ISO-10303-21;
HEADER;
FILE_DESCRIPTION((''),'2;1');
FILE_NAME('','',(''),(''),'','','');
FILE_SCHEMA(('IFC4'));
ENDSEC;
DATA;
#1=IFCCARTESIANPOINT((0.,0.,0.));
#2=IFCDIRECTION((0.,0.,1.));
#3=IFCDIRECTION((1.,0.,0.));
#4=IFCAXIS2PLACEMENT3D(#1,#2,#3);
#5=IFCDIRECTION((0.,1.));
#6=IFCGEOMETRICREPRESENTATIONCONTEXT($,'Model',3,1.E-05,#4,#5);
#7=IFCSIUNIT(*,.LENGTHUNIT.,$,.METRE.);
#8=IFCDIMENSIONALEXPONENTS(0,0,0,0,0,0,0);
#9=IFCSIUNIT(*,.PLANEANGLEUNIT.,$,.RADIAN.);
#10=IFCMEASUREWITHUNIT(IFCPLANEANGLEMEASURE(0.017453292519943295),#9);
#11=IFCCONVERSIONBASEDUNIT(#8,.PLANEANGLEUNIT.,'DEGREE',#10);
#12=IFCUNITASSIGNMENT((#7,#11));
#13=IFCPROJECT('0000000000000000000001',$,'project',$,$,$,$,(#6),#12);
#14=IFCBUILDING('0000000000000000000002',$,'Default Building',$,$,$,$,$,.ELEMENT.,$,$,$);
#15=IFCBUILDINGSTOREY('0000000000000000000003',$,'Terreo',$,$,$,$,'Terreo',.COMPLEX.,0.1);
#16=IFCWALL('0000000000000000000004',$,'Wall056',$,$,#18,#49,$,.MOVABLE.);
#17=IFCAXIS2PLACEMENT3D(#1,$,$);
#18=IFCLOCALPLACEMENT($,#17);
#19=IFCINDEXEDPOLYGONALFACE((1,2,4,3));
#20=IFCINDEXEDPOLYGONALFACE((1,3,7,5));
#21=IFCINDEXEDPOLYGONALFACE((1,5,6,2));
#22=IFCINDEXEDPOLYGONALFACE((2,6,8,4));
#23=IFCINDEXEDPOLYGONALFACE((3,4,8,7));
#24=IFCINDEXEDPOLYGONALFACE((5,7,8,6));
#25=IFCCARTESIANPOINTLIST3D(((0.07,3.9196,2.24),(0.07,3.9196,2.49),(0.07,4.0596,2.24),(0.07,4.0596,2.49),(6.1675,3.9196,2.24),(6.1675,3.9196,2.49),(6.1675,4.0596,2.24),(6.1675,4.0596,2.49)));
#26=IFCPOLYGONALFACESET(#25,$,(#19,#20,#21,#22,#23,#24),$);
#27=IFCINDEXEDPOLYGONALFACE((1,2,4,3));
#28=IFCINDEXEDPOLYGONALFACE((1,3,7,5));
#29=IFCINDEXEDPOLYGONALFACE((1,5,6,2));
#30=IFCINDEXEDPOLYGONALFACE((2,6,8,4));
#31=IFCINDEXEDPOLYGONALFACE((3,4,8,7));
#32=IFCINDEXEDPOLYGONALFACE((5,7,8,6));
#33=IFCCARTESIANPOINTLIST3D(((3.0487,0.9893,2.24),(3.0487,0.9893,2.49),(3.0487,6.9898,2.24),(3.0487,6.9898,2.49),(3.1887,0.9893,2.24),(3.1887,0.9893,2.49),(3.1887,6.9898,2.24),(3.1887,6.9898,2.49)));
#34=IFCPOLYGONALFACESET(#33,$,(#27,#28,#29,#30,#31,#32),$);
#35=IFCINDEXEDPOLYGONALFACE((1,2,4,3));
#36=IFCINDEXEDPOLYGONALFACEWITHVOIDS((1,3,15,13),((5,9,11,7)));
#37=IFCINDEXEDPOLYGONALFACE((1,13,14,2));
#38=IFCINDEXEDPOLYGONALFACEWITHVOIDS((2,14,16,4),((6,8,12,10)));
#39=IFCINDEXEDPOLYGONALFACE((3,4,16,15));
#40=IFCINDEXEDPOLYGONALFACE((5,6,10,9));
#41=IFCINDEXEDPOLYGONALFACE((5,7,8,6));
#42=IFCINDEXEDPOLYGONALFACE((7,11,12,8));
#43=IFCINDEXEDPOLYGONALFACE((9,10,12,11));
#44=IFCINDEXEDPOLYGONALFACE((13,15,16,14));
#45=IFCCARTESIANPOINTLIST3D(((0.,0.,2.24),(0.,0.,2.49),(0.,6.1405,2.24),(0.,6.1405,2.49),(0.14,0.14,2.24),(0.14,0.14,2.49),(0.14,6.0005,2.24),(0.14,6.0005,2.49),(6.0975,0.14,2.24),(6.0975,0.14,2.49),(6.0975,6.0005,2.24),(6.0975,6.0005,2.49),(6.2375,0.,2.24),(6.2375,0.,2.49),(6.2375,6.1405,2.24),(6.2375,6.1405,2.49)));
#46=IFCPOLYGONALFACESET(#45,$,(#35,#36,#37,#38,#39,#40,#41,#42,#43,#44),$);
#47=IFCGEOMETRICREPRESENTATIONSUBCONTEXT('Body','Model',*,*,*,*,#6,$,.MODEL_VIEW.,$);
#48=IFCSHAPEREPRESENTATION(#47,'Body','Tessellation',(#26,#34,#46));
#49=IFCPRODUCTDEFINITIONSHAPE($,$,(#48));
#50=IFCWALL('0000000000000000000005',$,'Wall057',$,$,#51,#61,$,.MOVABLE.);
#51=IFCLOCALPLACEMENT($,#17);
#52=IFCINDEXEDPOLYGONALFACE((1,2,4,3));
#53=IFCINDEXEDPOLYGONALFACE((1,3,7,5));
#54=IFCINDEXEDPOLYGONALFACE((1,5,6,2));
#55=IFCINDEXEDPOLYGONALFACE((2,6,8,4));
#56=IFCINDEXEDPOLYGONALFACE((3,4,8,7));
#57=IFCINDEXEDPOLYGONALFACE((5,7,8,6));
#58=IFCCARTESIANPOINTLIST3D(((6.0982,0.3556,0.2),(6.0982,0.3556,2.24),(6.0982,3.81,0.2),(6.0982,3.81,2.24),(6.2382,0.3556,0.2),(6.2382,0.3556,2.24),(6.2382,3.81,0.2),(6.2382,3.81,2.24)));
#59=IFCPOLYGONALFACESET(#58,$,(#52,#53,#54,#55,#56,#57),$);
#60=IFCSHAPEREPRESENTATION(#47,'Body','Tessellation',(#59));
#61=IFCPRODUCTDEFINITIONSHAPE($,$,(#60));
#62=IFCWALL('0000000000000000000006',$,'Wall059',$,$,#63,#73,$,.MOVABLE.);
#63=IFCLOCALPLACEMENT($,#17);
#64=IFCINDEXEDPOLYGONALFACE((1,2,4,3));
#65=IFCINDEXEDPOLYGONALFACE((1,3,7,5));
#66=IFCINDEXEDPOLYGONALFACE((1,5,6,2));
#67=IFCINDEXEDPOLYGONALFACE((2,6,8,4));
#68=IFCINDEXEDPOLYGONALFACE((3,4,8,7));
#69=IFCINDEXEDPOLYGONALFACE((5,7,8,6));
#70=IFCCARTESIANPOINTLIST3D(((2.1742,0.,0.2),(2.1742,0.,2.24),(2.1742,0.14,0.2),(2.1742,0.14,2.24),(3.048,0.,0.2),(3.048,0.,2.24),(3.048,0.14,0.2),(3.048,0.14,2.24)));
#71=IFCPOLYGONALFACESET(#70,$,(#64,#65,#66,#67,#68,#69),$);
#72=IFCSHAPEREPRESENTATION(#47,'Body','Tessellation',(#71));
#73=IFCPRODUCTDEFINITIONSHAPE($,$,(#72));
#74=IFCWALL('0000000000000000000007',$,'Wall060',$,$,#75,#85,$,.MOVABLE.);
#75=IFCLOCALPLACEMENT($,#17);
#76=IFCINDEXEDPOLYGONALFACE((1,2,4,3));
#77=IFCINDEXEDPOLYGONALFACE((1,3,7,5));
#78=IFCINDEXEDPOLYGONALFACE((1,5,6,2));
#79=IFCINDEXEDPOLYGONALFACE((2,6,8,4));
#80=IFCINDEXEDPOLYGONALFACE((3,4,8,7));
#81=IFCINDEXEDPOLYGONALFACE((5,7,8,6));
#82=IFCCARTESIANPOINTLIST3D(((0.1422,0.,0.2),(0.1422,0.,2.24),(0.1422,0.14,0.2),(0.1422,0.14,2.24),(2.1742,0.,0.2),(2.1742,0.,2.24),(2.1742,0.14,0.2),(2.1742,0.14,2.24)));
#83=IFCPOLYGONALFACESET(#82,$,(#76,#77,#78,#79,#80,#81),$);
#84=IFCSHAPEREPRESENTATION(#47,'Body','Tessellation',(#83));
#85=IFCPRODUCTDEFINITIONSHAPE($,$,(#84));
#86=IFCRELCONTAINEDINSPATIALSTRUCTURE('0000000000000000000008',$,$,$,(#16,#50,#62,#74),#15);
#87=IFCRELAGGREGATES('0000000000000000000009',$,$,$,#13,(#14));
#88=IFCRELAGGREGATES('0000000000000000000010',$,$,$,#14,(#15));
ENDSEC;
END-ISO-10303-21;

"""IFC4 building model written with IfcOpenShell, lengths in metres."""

from ifc_helpers import new_model, entity, si_unit, converted_unit, direction, frame, frame_2d, origin_with_axes, origin_2d_with_axis, place, context, subcontext, project, spatial, polyline, rectangle, outline, extrude, element, save


model = new_model("IFC4")

# Units and contexts
model_context = context("Model", 3, precision=1e-05, world=origin_with_axes(), true_north=direction((0.0, 1.0)))
body_context = subcontext(model_context, "Body", "Model", "MODEL_VIEW")
ifc_project = project(units=[si_unit("LENGTHUNIT", "METRE"), converted_unit("PLANEANGLEUNIT", "DEGREE", entity("IfcPlaneAngleMeasure", 0.017453292519943295), si_unit("PLANEANGLEUNIT", "RADIAN"), dimensions=[0, 0, 0, 0, 0, 0, 0])], contexts=[model_context])

# Building, storey
building = spatial("IfcBuilding", under=ifc_project, Name="Default Building", CompositionType="ELEMENT")
storey = spatial("IfcBuildingStorey", under=building, Name="Terreo", LongName="Terreo", CompositionType="COMPLEX", Elevation=0.1)

# Shared definitions
placement = place(None, origin_with_axes())

# Walls
element("IfcWall", 1, at=placement, inside=storey, Name="Wall056", PredefinedType="MOVABLE", context=body_context, shape_type="SweptSolid", body=[
    extrude(rectangle(XDim=6.0975, YDim=0.14, at=origin_2d_with_axis()), frame((3.1187, 3.9896, 2.24), z_axis=(0.0, 0.0, 1.0), x_axis=(1.0, 0.0, 0.0)), (0.0, 0.0, 1.0), 0.25),
    extrude(rectangle(XDim=6.0005, YDim=0.14, at=frame_2d((0.0, 0.0), x_axis=(0.0, 1.0))), frame((3.1187, 3.9896, 2.24), z_axis=(0.0, 0.0, 1.0), x_axis=(1.0, 0.0, 0.0)), (0.0, 0.0, 1.0), 0.25),
    extrude(outline(polyline([(-3.1187, -3.9896), (3.1187, -3.9896), (3.1187, 2.151), (-3.1187, 2.151), (-3.1187, -3.9896)]), holes=[polyline([(2.9787, -3.8496), (2.9787, 2.011), (-2.9787, 2.011), (-2.9787, -3.8496), (2.9787, -3.8496)])]), frame((3.1187, 3.9896, 2.24), z_axis=(0.0, 0.0, 1.0), x_axis=(1.0, 0.0, 0.0)), (0.0, 0.0, 1.0), 0.25),
])
element("IfcWall", 2, at=placement, inside=storey, Name="Wall057", PredefinedType="MOVABLE", context=body_context, shape_type="SweptSolid", body=[
    extrude(rectangle(XDim=3.4544, YDim=0.14, at=frame_2d((0.0, 0.0), x_axis=(0.0, 1.0))), frame((6.1682, 2.0828, 0.2), z_axis=(0.0, 0.0, 1.0), x_axis=(1.0, 0.0, 0.0)), (0.0, 0.0, 1.0), 2.04),
])
element("IfcWall", 3, at=placement, inside=storey, Name="Wall059", PredefinedType="MOVABLE", context=body_context, shape_type="SweptSolid", body=[
    extrude(rectangle(XDim=0.8738, YDim=0.14, at=origin_2d_with_axis()), frame((2.6111, 0.07, 0.2), z_axis=(0.0, 0.0, 1.0), x_axis=(1.0, 0.0, 0.0)), (0.0, 0.0, 1.0), 2.04),
])
element("IfcWall", 4, at=placement, inside=storey, Name="Wall060", PredefinedType="MOVABLE", context=body_context, shape_type="SweptSolid", body=[
    extrude(rectangle(XDim=2.032, YDim=0.14, at=frame_2d((0.0, 0.0), x_axis=(1.0, 0.0))), frame((1.1582, 0.07, 0.2), z_axis=(0.0, 0.0, 1.0), x_axis=(1.0, 0.0, 0.0)), (0.0, 0.0, 1.0), 2.04),
])

save(model, "model.ifc")
